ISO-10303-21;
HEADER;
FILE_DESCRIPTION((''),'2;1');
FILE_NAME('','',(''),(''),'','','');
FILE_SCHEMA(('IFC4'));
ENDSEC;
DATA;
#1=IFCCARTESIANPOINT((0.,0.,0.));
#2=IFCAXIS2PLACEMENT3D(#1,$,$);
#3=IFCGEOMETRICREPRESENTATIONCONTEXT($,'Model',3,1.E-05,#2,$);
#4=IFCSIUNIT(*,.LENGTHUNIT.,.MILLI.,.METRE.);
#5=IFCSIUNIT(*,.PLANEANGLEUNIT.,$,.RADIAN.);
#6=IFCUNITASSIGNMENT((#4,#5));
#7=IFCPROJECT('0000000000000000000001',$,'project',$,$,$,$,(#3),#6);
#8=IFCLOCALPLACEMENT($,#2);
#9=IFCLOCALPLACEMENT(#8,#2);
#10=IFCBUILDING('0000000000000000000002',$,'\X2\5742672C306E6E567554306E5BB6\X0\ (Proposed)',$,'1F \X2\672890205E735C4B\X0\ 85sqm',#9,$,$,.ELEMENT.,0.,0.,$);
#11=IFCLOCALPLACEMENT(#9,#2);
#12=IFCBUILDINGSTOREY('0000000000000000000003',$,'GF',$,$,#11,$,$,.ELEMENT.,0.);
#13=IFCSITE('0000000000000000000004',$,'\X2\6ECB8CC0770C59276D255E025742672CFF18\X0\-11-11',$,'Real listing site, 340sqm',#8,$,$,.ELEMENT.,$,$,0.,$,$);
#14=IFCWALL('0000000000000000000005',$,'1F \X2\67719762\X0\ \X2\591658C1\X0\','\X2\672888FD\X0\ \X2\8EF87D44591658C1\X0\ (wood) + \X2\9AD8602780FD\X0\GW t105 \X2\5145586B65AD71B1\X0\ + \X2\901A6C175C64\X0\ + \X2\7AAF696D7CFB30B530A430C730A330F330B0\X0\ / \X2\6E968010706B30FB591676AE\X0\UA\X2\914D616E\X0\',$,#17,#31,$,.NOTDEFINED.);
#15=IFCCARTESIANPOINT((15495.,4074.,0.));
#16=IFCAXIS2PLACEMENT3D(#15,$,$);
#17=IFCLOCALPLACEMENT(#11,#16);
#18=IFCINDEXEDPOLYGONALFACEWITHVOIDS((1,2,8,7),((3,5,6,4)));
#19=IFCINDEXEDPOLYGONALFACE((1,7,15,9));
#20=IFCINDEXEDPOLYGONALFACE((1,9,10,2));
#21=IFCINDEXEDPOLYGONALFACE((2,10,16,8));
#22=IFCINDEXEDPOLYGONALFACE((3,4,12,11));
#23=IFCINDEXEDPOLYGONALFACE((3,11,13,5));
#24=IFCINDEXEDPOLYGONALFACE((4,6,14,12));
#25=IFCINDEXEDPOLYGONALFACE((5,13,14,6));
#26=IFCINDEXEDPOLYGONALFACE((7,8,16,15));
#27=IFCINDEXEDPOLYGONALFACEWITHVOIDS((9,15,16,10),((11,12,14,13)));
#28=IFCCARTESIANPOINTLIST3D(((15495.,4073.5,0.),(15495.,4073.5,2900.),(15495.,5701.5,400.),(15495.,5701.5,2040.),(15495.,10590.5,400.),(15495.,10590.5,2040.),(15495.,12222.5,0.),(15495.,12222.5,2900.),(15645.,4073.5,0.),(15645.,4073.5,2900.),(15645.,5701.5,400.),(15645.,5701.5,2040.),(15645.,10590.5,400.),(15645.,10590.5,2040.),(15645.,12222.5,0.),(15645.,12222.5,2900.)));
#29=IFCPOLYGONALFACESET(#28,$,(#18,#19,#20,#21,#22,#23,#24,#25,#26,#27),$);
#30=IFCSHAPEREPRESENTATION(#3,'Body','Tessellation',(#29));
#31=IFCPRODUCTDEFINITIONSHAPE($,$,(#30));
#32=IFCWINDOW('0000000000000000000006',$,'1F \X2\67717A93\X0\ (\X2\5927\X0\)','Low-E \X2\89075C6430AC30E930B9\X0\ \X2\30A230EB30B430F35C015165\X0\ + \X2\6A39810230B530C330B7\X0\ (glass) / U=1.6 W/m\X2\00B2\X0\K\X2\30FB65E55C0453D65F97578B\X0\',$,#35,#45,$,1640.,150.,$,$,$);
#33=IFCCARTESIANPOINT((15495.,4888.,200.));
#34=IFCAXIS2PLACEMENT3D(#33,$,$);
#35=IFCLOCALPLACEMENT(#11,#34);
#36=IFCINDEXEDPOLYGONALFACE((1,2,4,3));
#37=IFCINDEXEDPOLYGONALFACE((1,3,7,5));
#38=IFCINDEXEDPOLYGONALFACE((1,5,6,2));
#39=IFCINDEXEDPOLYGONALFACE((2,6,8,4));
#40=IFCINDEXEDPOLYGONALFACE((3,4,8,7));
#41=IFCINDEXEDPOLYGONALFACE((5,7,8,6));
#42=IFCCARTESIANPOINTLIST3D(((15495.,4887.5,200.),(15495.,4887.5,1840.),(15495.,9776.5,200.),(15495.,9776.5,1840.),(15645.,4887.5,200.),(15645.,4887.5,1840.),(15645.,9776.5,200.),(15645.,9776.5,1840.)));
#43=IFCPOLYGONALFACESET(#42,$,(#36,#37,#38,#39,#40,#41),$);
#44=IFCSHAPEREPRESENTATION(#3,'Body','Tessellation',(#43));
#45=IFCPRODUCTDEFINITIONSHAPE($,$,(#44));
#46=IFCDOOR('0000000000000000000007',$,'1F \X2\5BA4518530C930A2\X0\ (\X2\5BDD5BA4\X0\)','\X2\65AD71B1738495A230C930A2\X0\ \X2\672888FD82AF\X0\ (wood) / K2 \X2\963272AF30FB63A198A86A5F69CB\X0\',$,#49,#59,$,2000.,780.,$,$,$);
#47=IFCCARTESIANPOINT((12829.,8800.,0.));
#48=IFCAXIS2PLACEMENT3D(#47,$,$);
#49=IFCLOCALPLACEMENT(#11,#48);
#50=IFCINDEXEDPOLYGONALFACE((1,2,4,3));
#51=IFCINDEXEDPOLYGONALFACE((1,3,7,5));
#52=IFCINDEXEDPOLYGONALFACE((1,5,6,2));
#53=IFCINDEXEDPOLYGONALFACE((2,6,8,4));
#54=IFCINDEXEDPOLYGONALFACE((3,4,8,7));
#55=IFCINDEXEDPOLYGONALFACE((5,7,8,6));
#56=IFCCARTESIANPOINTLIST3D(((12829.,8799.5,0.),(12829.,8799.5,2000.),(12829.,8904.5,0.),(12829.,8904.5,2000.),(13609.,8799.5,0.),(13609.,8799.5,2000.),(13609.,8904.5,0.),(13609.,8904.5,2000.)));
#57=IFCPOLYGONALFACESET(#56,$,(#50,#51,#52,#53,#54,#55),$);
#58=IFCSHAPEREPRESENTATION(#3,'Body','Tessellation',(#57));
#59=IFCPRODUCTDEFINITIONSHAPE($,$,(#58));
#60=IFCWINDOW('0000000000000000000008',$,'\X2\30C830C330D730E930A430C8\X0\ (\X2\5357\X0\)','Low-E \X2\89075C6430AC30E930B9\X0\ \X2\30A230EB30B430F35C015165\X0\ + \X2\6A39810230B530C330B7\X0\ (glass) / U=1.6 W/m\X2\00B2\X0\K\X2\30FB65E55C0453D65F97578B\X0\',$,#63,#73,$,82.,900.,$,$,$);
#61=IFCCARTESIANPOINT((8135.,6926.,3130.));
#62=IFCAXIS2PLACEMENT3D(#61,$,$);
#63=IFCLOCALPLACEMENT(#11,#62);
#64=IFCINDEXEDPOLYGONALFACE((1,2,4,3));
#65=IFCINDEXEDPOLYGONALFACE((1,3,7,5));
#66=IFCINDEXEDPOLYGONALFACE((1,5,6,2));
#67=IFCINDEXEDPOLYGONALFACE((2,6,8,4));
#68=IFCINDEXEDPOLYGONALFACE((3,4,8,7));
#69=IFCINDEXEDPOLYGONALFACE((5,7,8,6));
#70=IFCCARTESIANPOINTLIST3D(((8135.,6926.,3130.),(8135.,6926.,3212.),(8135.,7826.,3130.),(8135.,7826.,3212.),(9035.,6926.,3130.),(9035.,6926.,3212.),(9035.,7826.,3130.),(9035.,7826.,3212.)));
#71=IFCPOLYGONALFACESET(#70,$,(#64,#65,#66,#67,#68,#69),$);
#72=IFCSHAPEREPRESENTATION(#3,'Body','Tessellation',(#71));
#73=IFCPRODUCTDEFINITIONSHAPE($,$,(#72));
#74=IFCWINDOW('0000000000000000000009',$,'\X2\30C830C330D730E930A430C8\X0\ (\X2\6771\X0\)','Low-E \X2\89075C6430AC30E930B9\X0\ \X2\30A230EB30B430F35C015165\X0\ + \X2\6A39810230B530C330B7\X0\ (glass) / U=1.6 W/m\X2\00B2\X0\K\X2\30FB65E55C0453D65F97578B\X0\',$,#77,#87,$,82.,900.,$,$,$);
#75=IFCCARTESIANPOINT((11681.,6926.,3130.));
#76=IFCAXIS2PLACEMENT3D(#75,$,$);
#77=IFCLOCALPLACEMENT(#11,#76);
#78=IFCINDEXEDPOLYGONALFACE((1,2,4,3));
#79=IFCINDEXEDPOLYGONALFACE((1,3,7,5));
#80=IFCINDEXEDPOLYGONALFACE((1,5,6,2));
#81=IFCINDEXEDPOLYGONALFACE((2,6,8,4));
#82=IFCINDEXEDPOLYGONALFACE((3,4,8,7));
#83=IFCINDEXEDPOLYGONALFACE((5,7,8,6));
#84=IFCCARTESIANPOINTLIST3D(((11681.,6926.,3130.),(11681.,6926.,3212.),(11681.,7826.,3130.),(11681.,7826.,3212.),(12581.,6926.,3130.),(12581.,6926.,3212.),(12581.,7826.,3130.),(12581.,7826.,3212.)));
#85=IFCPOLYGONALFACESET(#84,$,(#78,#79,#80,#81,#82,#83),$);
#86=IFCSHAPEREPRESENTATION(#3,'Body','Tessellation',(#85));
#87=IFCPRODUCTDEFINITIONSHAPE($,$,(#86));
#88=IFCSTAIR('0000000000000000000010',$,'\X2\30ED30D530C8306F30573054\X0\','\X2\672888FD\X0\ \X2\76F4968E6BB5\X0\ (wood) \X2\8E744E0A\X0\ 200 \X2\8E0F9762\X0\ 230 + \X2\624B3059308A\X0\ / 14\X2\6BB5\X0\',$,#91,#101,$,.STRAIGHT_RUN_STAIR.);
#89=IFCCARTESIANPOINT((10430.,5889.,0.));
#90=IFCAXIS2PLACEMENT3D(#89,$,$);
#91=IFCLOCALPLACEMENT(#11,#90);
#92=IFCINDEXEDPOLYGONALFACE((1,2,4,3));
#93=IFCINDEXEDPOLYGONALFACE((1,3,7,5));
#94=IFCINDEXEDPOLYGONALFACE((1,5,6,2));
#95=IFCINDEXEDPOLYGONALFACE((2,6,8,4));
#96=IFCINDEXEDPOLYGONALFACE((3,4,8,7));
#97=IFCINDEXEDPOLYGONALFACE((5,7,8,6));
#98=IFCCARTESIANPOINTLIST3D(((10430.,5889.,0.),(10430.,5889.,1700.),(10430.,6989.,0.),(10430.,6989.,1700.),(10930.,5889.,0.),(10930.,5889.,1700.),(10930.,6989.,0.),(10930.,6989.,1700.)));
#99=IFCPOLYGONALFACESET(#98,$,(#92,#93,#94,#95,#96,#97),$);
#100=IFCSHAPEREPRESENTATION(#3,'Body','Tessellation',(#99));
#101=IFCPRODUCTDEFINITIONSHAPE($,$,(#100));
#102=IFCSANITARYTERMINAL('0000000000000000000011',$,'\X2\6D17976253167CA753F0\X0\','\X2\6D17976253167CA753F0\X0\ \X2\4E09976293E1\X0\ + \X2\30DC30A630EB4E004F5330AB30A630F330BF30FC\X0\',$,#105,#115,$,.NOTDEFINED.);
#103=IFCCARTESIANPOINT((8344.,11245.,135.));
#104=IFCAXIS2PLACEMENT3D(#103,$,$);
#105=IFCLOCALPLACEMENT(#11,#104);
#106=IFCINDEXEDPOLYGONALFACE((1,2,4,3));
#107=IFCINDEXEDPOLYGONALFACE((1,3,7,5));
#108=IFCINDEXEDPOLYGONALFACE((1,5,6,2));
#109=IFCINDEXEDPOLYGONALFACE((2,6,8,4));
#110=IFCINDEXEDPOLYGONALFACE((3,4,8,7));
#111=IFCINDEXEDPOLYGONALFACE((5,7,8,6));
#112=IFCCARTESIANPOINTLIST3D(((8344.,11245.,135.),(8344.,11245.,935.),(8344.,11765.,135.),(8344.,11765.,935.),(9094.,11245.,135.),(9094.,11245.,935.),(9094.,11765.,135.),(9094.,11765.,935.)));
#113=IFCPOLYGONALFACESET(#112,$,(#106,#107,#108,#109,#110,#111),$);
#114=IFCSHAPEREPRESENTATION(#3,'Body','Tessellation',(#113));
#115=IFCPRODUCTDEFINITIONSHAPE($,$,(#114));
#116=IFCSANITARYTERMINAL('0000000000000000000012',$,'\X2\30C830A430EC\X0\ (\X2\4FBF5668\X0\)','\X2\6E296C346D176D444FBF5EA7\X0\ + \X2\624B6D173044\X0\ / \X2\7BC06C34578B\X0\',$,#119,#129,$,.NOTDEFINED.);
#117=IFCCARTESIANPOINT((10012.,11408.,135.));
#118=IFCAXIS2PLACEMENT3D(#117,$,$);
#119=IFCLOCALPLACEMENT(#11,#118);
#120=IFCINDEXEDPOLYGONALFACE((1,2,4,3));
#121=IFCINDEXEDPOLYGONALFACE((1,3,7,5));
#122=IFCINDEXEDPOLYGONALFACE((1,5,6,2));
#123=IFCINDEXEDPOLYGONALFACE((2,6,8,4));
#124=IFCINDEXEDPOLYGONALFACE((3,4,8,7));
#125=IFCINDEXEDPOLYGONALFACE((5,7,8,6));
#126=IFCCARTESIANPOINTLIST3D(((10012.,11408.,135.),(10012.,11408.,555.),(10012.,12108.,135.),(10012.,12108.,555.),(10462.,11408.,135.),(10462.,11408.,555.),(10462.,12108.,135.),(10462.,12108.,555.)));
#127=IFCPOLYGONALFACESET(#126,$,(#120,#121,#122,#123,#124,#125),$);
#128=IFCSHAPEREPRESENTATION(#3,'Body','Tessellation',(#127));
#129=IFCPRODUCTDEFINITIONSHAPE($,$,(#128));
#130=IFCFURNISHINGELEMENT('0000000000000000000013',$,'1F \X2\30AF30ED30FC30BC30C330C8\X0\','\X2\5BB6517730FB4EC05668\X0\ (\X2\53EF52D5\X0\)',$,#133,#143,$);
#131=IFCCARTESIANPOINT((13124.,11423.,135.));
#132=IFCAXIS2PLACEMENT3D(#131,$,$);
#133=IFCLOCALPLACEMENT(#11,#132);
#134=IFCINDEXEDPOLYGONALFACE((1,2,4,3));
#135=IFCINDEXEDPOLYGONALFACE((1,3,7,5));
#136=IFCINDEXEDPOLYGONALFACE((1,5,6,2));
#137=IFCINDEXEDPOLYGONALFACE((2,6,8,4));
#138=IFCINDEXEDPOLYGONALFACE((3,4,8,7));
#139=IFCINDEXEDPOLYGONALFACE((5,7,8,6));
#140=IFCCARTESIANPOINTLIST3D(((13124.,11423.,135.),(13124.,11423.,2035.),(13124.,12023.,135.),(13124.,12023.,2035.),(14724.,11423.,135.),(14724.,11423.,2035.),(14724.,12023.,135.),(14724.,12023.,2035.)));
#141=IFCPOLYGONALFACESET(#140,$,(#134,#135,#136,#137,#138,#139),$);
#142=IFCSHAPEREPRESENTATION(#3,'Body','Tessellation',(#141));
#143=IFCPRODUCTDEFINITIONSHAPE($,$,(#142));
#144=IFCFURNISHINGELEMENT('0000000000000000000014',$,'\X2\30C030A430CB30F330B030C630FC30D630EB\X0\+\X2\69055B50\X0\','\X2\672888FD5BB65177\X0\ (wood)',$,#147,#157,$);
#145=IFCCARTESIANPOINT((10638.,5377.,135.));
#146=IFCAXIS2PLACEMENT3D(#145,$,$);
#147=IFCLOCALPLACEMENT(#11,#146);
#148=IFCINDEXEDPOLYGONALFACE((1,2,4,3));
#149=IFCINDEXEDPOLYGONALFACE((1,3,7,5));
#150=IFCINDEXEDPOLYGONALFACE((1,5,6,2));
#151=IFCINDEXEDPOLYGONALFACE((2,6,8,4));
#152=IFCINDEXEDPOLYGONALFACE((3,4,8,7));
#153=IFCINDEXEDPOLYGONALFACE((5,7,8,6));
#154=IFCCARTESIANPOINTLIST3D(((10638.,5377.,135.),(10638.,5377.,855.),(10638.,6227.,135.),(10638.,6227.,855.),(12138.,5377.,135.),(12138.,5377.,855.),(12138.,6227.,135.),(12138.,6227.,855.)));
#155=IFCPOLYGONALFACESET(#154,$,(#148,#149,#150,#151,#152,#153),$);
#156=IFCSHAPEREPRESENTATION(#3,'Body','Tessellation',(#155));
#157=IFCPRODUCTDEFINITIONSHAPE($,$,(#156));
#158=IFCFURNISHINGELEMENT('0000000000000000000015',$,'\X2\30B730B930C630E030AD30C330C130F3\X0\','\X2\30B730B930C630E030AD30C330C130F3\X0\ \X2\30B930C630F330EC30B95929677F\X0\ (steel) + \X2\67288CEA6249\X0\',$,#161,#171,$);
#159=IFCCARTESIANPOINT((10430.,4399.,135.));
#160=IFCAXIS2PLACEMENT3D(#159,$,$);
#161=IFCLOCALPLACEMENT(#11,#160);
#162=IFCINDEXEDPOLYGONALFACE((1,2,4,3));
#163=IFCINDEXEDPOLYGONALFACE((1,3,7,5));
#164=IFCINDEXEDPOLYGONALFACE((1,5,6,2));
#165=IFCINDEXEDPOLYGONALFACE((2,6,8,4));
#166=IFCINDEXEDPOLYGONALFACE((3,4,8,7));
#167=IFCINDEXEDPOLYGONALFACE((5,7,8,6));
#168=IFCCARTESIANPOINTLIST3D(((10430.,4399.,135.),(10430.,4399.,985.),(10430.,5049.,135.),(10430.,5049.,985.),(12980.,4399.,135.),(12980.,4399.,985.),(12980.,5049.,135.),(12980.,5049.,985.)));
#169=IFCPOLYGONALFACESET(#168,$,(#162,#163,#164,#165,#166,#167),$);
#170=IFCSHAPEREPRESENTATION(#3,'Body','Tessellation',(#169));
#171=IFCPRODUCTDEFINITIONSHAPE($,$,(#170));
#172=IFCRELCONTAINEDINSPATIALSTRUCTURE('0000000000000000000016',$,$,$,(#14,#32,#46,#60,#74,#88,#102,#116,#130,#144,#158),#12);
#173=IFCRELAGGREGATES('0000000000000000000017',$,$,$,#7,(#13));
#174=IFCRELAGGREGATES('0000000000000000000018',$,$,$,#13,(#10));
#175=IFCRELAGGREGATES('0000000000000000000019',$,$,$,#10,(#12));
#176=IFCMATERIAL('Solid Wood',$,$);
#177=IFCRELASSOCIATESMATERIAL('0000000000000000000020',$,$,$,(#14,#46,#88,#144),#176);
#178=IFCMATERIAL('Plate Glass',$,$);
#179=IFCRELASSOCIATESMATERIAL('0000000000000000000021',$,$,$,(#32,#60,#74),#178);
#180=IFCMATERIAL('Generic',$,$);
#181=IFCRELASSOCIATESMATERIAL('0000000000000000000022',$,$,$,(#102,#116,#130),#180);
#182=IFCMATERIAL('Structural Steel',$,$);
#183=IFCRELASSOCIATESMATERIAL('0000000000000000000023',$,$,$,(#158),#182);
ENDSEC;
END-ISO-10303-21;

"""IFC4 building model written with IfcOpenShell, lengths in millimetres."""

from ifc_helpers import new_model, si_unit, frame, frame_2d, origin, place, context, project, spatial, rectangle, extrude, material, element, fill, save


model = new_model("IFC4")

# Units and contexts
model_context = context("Model", 3, precision=1e-05, world=origin())
ifc_project = project(units=[si_unit("LENGTHUNIT", "METRE", prefix="MILLI"), si_unit("PLANEANGLEUNIT", "RADIAN")], contexts=[model_context])

# Site, building, storey
site_placement = place(None, origin())
site = spatial("IfcSite", under=ifc_project, at=site_placement, Name="滋賀県大津市坂本８-11-11", ObjectType="Real listing site, 340sqm", CompositionType="ELEMENT", RefElevation=0.0)
building_placement = place(site_placement, origin())
building = spatial("IfcBuilding", under=site, at=building_placement, Name="坂本の湖畔の家 (Proposed)", ObjectType="1F 木造平屋 85sqm", CompositionType="ELEMENT", ElevationOfRefHeight=0.0, ElevationOfTerrain=0.0)
storey_placement = place(building_placement, origin())
storey = spatial("IfcBuildingStorey", under=building, at=storey_placement, Name="GF", CompositionType="ELEMENT", Elevation=0.0)

# Wall, opening, window
ifc_material_1 = material(Name="Solid Wood")
wall_1_placement = place(storey_placement, frame((15495.0, 4074.0, 0.0)))
wall_1 = element("IfcWall", 1, at=wall_1_placement, inside=storey, material=ifc_material_1, Name="1F 東面 外壁", Description="木製 軸組外壁 (wood) + 高性能GW t105 充填断熱 + 通気層 + 窯業系サイディング / 準耐火・外皮UA配慮", PredefinedType="NOTDEFINED", context=model_context, shape_type="SweptSolid", body=[
    extrude(rectangle(XDim=150.0, YDim=8149.0, at=frame_2d((75.0, 4074.0))), frame((15495.0, 4074.0, 0.0)), (0.0, 0.0, 1.0), 2900.0),
])
opening_placement = place(storey_placement, frame((15495.0, 4888.0, 200.0)))
opening = element("IfcOpeningElement", 2, at=opening_placement, cuts=wall_1, PredefinedType="NOTDEFINED", context=model_context, shape_type="SweptSolid", body=[
    extrude(rectangle(XDim=150.0, YDim=4889.0, at=frame_2d((75.0, 2444.0))), frame((15495.0, 4888.0, 200.0)), (0.0, 0.0, 1.0), 1640.0),
])
ifc_material_2 = material(Name="Plate Glass")
window_1_placement = place(storey_placement, frame((15495.0, 4888.0, 200.0)))
window_1 = element("IfcWindow", 3, at=window_1_placement, inside=storey, material=ifc_material_2, Name="1F 東窓 (大)", Description="Low-E 複層ガラス アルゴン封入 + 樹脂サッシ (glass) / U=1.6 W/m²K・日射取得型", OverallHeight=1640.0, OverallWidth=150.0, context=model_context, shape_type="SweptSolid", body=[
    extrude(rectangle(XDim=150.0, YDim=4889.0, at=frame_2d((75.0, 2444.0))), frame((15495.0, 4888.0, 200.0)), (0.0, 0.0, 1.0), 1640.0),
])
fill(opening, window_1)

# Door
door_placement = place(storey_placement, frame((12829.0, 8800.0, 0.0)))
element("IfcDoor", 4, at=door_placement, inside=storey, material=ifc_material_1, Name="1F 室内ドア (寝室)", Description="断熱玄関ドア 木製芯 (wood) / K2 防犯・採風機構", OverallHeight=2000.0, OverallWidth=780.0, context=model_context, shape_type="SweptSolid", body=[
    extrude(rectangle(XDim=780.0, YDim=105.0, at=frame_2d((390.0, 52.0))), frame((12829.0, 8800.0, 0.0)), (0.0, 0.0, 1.0), 2000.0),
])

# Windows
window_2_placement = place(storey_placement, frame((8135.0, 6926.0, 3130.0)))
element("IfcWindow", 5, at=window_2_placement, inside=storey, material=ifc_material_2, Name="トップライト (南)", Description="Low-E 複層ガラス アルゴン封入 + 樹脂サッシ (glass) / U=1.6 W/m²K・日射取得型", OverallHeight=82.0, OverallWidth=900.0, context=model_context, shape_type="SweptSolid", body=[
    extrude(rectangle(XDim=900.0, YDim=900.0, at=frame_2d((450.0, 450.0))), frame((8135.0, 6926.0, 3130.0)), (0.0, 0.0, 1.0), 82.0),
])
window_3_placement = place(storey_placement, frame((11681.0, 6926.0, 3130.0)))
element("IfcWindow", 6, at=window_3_placement, inside=storey, material=ifc_material_2, Name="トップライト (東)", Description="Low-E 複層ガラス アルゴン封入 + 樹脂サッシ (glass) / U=1.6 W/m²K・日射取得型", OverallHeight=82.0, OverallWidth=900.0, context=model_context, shape_type="SweptSolid", body=[
    extrude(rectangle(XDim=900.0, YDim=900.0, at=frame_2d((450.0, 450.0))), frame((11681.0, 6926.0, 3130.0)), (0.0, 0.0, 1.0), 82.0),
])

# Stair
stair_placement = place(storey_placement, frame((10430.0, 5889.0, 0.0)))
element("IfcStair", 7, at=stair_placement, inside=storey, material=ifc_material_1, Name="ロフトはしご", Description="木製 直階段 (wood) 蹴上 200 踏面 230 + 手すり / 14段", PredefinedType="STRAIGHT_RUN_STAIR", context=model_context, shape_type="SweptSolid", body=[
    extrude(rectangle(XDim=500.0, YDim=1100.0, at=frame_2d((250.0, 550.0))), frame((10430.0, 5889.0, 0.0)), (0.0, 0.0, 1.0), 1700.0),
])

# Sanitary terminals
ifc_material_3 = material(Name="Generic")
sanitary_terminal_1_placement = place(storey_placement, frame((8344.0, 11245.0, 135.0)))
element("IfcSanitaryTerminal", 8, at=sanitary_terminal_1_placement, inside=storey, material=ifc_material_3, Name="洗面化粧台", Description="洗面化粧台 三面鏡 + ボウル一体カウンター", PredefinedType="NOTDEFINED", context=model_context, shape_type="SweptSolid", body=[
    extrude(rectangle(XDim=750.0, YDim=520.0, at=frame_2d((375.0, 260.0))), frame((8344.0, 11245.0, 135.0)), (0.0, 0.0, 1.0), 800.0),
])
sanitary_terminal_2_placement = place(storey_placement, frame((10012.0, 11408.0, 135.0)))
element("IfcSanitaryTerminal", 9, at=sanitary_terminal_2_placement, inside=storey, material=ifc_material_3, Name="トイレ (便器)", Description="温水洗浄便座 + 手洗い / 節水型", PredefinedType="NOTDEFINED", context=model_context, shape_type="SweptSolid", body=[
    extrude(rectangle(XDim=450.0, YDim=700.0, at=frame_2d((225.0, 350.0))), frame((10012.0, 11408.0, 135.0)), (0.0, 0.0, 1.0), 420.0),
])

# Furnishing elements
furnishing_1_placement = place(storey_placement, frame((13124.0, 11423.0, 135.0)))
element("IfcFurnishingElement", 10, at=furnishing_1_placement, inside=storey, material=ifc_material_3, Name="1F クローゼット", Description="家具・什器 (可動)", context=model_context, shape_type="SweptSolid", body=[
    extrude(rectangle(XDim=1600.0, YDim=600.0, at=frame_2d((800.0, 300.0))), frame((13124.0, 11423.0, 135.0)), (0.0, 0.0, 1.0), 1900.0),
])
furnishing_2_placement = place(storey_placement, frame((10638.0, 5377.0, 135.0)))
element("IfcFurnishingElement", 11, at=furnishing_2_placement, inside=storey, material=ifc_material_1, Name="ダイニングテーブル+椅子", Description="木製家具 (wood)", context=model_context, shape_type="SweptSolid", body=[
    extrude(rectangle(XDim=1500.0, YDim=850.0, at=frame_2d((750.0, 425.0))), frame((10638.0, 5377.0, 135.0)), (0.0, 0.0, 1.0), 720.0),
])
ifc_material_4 = material(Name="Structural Steel")
furnishing_3_placement = place(storey_placement, frame((10430.0, 4399.0, 135.0)))
element("IfcFurnishingElement", 12, at=furnishing_3_placement, inside=storey, material=ifc_material_4, Name="システムキッチン", Description="システムキッチン ステンレス天板 (steel) + 木質扉", context=model_context, shape_type="SweptSolid", body=[
    extrude(rectangle(XDim=2550.0, YDim=650.0, at=frame_2d((1275.0, 325.0))), frame((10430.0, 4399.0, 135.0)), (0.0, 0.0, 1.0), 850.0),
])

save(model, "model.ifc")
